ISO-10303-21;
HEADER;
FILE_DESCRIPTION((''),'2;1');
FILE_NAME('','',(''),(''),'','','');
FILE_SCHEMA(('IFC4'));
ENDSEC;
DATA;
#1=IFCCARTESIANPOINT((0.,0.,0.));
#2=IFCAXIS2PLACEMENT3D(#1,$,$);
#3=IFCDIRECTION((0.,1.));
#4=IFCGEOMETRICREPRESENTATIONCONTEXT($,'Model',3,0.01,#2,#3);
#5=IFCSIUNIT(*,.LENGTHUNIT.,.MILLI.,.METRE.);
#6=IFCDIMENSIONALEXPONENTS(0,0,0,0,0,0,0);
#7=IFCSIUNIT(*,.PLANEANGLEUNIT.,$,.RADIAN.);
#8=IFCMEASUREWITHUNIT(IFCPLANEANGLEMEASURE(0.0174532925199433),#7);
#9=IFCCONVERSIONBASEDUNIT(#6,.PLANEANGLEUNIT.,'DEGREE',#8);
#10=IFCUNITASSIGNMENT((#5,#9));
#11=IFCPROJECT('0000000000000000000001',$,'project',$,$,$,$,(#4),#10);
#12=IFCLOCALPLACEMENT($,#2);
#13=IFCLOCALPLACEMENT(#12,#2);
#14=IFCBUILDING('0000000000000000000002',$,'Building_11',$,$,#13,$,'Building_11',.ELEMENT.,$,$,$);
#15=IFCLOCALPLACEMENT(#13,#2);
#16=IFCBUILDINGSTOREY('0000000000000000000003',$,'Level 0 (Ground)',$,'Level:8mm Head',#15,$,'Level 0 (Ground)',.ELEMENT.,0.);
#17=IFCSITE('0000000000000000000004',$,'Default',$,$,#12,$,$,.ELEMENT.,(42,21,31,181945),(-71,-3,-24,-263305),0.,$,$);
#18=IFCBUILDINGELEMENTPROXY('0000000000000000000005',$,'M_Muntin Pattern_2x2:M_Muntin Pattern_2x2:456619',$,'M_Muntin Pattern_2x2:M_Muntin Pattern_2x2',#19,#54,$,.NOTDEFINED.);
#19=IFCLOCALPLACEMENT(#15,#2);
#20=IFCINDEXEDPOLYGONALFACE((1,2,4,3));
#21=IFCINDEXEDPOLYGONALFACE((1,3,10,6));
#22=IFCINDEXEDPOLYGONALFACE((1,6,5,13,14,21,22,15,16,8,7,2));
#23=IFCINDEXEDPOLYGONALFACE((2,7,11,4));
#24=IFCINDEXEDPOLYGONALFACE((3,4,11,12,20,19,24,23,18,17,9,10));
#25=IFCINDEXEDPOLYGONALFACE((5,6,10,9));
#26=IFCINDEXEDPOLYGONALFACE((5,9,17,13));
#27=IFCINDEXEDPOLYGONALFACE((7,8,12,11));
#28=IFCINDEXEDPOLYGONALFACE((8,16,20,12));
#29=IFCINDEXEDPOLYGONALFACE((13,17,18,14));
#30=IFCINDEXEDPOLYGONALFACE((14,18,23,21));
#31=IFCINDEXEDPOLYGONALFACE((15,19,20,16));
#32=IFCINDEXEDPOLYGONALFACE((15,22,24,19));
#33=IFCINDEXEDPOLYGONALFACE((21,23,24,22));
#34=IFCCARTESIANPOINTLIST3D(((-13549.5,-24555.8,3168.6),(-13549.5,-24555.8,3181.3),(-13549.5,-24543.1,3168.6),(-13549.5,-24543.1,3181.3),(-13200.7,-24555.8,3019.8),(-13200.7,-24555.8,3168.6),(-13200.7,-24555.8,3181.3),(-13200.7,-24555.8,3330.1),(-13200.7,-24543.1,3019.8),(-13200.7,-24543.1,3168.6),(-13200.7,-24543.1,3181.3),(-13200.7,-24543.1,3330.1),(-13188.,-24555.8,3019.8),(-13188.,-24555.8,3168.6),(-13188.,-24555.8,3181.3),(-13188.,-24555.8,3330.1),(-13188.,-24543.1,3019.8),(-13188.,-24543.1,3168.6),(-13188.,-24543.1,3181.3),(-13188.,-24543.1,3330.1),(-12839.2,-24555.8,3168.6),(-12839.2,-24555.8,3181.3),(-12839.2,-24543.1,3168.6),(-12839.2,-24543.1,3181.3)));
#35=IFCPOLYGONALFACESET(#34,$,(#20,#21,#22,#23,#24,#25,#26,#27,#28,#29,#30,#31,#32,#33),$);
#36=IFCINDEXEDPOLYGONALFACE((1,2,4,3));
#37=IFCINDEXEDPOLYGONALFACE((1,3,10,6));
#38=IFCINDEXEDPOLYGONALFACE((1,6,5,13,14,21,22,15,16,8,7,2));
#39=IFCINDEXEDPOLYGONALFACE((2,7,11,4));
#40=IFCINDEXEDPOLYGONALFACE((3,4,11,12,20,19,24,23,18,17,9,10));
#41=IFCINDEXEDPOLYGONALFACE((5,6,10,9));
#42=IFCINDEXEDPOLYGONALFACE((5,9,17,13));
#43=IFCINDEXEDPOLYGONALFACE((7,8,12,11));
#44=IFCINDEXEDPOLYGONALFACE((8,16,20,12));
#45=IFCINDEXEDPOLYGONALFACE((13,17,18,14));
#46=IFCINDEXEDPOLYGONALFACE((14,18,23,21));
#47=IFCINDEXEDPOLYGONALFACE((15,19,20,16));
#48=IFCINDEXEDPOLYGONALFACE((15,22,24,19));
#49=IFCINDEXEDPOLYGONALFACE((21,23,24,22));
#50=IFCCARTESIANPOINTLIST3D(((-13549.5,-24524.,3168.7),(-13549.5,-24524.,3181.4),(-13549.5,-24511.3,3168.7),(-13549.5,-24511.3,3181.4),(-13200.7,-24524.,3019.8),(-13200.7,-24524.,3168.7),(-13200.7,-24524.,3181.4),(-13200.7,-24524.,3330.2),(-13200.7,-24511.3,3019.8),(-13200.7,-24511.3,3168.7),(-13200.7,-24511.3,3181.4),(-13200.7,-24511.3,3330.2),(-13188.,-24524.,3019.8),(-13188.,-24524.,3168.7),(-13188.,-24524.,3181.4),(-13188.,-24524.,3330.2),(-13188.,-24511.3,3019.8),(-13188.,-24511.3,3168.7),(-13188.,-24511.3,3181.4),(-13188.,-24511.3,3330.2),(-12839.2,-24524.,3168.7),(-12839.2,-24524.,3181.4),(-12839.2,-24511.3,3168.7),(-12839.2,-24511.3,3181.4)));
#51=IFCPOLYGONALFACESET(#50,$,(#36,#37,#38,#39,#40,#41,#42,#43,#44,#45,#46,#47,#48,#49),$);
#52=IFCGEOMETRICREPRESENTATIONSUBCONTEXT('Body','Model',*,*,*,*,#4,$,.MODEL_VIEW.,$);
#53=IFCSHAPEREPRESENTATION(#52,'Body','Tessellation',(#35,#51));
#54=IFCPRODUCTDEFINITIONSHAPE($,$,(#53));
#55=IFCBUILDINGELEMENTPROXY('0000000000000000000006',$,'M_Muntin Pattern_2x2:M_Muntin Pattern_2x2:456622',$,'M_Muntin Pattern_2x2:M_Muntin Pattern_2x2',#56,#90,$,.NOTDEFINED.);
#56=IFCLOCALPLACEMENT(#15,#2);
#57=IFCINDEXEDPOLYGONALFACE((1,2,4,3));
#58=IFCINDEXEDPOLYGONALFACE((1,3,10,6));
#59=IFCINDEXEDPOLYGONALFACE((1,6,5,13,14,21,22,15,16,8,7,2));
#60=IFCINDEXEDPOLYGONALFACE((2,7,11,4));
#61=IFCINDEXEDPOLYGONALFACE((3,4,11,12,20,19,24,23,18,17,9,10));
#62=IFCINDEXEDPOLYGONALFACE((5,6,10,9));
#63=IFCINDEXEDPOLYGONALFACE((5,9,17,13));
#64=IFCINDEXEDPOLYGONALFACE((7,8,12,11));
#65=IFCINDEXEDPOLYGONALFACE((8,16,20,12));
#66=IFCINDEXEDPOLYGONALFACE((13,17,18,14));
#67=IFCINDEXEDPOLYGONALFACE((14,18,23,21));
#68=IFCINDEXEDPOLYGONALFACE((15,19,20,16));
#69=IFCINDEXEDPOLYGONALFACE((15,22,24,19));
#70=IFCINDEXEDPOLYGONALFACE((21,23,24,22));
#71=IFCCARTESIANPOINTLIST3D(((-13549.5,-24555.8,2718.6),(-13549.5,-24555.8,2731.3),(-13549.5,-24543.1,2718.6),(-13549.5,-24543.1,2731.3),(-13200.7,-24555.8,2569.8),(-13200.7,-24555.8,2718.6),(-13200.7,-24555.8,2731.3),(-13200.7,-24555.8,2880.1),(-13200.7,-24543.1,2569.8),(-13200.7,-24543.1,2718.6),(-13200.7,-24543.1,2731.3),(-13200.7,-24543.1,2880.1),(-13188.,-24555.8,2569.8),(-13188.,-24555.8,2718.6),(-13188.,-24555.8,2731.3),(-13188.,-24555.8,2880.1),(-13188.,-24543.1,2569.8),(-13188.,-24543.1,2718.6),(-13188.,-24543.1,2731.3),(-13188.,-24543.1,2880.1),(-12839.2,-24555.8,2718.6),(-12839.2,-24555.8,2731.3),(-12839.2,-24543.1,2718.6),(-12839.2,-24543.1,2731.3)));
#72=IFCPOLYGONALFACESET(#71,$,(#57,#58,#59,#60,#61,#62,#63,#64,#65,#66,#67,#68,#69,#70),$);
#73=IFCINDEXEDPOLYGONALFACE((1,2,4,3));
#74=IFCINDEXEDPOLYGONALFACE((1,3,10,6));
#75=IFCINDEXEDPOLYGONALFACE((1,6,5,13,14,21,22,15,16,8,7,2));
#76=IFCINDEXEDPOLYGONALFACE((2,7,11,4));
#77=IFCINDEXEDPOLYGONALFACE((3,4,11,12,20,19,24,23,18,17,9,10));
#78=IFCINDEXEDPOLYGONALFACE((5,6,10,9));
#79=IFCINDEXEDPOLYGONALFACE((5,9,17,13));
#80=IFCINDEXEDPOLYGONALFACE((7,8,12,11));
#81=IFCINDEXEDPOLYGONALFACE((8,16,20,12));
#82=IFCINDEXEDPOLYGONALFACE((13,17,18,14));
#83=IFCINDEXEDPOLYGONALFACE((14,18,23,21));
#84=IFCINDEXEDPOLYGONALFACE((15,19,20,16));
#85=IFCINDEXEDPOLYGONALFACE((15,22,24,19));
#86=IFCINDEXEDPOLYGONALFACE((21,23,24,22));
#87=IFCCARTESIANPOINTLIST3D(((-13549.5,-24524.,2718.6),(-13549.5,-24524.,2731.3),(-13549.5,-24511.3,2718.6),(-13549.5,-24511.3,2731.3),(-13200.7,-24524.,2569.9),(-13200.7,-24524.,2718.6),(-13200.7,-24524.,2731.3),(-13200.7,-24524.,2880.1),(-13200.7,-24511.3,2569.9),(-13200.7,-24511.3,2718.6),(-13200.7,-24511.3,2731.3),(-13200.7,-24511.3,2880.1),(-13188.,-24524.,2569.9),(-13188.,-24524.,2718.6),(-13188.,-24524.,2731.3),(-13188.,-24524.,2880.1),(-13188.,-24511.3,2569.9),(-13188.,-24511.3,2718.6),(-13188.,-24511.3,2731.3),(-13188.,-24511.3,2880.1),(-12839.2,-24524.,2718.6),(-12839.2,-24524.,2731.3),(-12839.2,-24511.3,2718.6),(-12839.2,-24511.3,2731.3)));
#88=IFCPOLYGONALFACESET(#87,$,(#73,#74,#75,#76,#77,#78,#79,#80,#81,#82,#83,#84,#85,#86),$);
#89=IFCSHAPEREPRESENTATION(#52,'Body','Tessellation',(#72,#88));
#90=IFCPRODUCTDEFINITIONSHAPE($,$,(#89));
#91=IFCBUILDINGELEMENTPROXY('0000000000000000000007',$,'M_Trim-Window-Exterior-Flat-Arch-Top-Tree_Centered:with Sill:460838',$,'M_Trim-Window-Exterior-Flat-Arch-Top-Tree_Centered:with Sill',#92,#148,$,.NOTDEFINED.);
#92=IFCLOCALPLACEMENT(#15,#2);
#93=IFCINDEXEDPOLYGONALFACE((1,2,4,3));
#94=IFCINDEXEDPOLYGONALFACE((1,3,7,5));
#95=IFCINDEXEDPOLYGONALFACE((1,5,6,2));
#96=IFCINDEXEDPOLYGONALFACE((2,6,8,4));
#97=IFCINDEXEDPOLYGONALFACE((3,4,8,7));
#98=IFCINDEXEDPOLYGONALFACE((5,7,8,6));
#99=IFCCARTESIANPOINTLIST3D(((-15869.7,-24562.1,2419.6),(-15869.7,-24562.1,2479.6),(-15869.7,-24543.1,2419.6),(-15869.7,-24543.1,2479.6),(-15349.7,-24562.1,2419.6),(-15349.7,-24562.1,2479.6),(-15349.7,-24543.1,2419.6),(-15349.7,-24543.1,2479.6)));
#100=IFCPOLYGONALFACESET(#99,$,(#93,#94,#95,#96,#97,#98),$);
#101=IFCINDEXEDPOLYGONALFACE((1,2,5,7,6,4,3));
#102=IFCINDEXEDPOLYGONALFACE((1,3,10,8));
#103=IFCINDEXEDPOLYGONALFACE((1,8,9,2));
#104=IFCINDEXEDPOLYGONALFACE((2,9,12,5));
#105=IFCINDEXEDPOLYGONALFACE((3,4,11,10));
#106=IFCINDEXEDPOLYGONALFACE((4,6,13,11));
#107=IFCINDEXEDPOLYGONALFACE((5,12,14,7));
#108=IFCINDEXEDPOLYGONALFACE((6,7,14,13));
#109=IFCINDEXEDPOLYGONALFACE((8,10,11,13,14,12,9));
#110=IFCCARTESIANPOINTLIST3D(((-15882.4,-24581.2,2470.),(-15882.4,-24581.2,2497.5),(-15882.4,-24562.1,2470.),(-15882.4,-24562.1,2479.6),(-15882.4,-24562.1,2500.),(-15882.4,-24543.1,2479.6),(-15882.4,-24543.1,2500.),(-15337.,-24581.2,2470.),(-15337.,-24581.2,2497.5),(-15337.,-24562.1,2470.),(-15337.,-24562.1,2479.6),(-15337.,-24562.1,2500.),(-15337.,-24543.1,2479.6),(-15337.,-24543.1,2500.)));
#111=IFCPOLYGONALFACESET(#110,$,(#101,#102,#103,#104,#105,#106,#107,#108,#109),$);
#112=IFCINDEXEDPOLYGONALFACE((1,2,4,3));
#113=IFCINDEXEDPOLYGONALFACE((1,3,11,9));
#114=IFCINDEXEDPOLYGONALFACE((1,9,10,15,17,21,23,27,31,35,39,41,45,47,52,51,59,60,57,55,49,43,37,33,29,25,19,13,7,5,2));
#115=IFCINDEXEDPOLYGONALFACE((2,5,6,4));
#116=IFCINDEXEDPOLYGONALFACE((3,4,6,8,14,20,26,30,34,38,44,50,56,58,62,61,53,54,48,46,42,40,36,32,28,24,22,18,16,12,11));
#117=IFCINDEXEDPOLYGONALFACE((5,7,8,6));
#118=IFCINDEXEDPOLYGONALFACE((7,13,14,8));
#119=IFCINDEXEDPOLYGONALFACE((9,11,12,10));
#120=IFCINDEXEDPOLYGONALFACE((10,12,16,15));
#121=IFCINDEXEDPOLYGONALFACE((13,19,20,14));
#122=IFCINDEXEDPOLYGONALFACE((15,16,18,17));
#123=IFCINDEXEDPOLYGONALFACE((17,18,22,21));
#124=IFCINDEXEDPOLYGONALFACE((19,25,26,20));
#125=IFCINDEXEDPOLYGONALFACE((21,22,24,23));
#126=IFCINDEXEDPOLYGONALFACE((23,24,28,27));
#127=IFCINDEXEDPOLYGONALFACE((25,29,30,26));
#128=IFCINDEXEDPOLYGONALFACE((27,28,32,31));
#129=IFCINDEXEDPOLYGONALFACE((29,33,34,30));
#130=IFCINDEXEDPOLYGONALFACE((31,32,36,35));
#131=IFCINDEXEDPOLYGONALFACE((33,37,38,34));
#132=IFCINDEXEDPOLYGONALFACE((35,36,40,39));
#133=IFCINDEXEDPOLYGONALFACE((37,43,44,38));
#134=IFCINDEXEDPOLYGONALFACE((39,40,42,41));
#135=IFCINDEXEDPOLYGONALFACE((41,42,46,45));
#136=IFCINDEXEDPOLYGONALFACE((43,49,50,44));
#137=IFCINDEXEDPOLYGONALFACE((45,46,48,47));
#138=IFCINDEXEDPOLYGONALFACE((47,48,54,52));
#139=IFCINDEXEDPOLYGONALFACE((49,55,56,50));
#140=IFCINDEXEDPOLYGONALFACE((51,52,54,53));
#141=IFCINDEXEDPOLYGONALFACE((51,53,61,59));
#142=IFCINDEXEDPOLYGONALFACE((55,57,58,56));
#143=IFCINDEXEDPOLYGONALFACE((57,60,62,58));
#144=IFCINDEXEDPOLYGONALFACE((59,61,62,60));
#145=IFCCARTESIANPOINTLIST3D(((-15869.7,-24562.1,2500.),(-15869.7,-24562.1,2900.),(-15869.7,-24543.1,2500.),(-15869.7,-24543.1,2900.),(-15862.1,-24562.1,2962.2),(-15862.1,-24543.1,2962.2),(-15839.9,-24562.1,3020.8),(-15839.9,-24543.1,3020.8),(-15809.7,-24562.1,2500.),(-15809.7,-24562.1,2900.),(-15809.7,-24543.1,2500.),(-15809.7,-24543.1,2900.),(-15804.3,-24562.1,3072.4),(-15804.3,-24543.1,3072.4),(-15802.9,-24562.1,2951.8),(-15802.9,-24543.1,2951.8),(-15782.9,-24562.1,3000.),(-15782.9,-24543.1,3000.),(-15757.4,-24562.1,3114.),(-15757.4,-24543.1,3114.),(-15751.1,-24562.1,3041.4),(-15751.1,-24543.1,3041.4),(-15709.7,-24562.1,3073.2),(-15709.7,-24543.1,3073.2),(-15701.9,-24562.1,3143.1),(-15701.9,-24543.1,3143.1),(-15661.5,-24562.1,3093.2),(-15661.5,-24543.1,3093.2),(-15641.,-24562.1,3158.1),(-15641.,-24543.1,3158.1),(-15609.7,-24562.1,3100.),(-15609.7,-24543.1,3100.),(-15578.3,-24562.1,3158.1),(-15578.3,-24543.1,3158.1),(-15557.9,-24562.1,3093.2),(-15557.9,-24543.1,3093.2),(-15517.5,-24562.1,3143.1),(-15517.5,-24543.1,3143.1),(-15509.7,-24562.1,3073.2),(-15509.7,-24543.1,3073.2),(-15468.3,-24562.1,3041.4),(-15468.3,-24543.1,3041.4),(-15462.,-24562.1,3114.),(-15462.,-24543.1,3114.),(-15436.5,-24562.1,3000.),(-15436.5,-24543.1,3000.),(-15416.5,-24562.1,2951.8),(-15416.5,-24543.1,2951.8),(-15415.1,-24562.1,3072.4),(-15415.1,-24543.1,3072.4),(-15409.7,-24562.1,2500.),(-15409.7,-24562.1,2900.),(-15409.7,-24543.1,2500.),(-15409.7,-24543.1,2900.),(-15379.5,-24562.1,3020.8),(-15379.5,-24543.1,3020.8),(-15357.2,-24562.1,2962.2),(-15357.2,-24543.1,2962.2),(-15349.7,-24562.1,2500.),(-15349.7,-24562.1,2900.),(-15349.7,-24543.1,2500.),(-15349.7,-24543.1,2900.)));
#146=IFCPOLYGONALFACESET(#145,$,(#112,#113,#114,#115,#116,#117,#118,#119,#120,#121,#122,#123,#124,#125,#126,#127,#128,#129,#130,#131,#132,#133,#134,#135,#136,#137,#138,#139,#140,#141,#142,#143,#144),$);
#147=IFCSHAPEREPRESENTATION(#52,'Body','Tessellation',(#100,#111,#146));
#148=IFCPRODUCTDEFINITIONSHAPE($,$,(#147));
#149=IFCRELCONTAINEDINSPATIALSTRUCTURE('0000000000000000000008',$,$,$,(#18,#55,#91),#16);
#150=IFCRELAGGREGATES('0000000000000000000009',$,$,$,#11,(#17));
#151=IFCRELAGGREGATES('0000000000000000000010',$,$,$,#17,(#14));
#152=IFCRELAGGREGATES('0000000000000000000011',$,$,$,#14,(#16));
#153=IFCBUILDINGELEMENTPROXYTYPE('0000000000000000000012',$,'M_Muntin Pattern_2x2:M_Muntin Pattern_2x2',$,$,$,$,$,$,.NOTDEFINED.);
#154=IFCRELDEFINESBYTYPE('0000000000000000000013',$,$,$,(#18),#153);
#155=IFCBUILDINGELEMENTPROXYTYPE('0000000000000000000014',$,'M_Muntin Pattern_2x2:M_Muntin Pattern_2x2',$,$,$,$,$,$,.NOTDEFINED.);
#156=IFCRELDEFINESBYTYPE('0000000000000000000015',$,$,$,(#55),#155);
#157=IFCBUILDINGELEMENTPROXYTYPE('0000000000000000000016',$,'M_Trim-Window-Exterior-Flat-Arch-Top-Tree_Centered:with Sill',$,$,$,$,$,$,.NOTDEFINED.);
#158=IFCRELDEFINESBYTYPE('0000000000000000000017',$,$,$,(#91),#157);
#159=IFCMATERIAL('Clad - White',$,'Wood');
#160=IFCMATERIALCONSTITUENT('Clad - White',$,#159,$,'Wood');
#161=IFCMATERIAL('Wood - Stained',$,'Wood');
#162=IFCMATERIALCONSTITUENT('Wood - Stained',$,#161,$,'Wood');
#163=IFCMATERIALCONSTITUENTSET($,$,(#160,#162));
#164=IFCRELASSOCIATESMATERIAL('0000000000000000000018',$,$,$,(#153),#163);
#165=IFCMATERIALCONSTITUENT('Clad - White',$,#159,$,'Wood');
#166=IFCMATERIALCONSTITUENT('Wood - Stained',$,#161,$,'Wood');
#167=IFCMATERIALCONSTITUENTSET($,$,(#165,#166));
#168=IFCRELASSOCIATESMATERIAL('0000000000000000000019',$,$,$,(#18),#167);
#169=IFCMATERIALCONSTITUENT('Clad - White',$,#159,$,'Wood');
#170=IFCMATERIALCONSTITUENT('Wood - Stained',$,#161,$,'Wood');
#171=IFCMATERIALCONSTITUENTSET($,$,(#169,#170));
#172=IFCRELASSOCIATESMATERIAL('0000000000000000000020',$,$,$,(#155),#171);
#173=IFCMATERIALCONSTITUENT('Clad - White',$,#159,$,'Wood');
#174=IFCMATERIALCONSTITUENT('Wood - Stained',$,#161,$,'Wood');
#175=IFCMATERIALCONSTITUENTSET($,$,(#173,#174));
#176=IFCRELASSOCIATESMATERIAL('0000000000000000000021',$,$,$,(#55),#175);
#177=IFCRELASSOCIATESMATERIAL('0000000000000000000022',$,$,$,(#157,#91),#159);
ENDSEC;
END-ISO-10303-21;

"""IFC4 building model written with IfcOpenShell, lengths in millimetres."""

from ifc_helpers import new_model, entity, si_unit, converted_unit, direction, frame, origin, place, context, subcontext, project, spatial, line, arc, indexed_curve, outline, extrude, source, transform, mapped, material, constituent, constituent_set, type_object, type_shapes, element, save


model = new_model("IFC4")

# Units and contexts
model_context = context("Model", 3, precision=0.01, world=origin(), true_north=direction((0.0, 1.0)))
body_context = subcontext(model_context, "Body", "Model", "MODEL_VIEW")
ifc_project = project(units=[si_unit("LENGTHUNIT", "METRE", prefix="MILLI"), converted_unit("PLANEANGLEUNIT", "DEGREE", entity("IfcPlaneAngleMeasure", 0.0174532925199433), si_unit("PLANEANGLEUNIT", "RADIAN"), dimensions=[0, 0, 0, 0, 0, 0, 0])], contexts=[model_context])

# Site, building, storey
site_placement = place(None, origin())
site = spatial("IfcSite", under=ifc_project, at=site_placement, Name="Default", CompositionType="ELEMENT", RefLatitude=(42, 21, 31, 181945), RefLongitude=(-71, -3, -24, -263305), RefElevation=0.0)
building_placement = place(site_placement, origin())
building = spatial("IfcBuilding", under=site, at=building_placement, Name="Building_11", LongName="Building_11", CompositionType="ELEMENT")
storey_placement = place(building_placement, origin())
storey = spatial("IfcBuildingStorey", under=building, at=storey_placement, Name="Level 0 (Ground)", ObjectType="Level:8mm Head", LongName="Level 0 (Ground)", CompositionType="ELEMENT", Elevation=0.0)

# Building element proxies
ifc_material_1 = material(Name="Clad - White", Category="Wood")
ifc_material_2 = material(Name="Wood - Stained", Category="Wood")
ifc_constituent_1 = constituent(ifc_material_1, Name="Clad - White", Category="Wood")
ifc_constituent_2 = constituent(ifc_material_2, Name="Wood - Stained", Category="Wood")
ifc_constituent_set_1 = constituent_set(constituents=[ifc_constituent_1, ifc_constituent_2])
ifc_constituent_3 = constituent(ifc_material_1, Name="Clad - White", Category="Wood")
ifc_constituent_4 = constituent(ifc_material_2, Name="Wood - Stained", Category="Wood")
ifc_constituent_set_2 = constituent_set(constituents=[ifc_constituent_3, ifc_constituent_4])
building_element_proxy_type_1 = type_object("IfcBuildingElementProxyType", Name="M_Muntin Pattern_2x2:M_Muntin Pattern_2x2", PredefinedType="NOTDEFINED", material=ifc_constituent_set_2)
shared_shape_1 = source(origin(), body_context, "Body", "SweptSolid", [
    extrude(outline(indexed_curve([(6.4, -6.4), (155.1, -6.4), (155.1, 6.3), (6.4, 6.3), (6.4, 355.2), (-6.3, 355.2), (-6.3, 6.3), (-155.2, 6.3), (-155.2, -6.4), (-6.3, -6.4), (-6.3, -355.1), (6.4, -355.1), (6.4, -6.4)], self_intersect=False)), frame((0.0, 9.5, 155.1), z_axis=(0.0, 1.0, 0.0), x_axis=(0.0, 0.0, 1.0)), (0.0, 0.0, 1.0), 12.7),
    extrude(outline(indexed_curve([(6.4, -6.4), (155.2, -6.4), (155.2, 6.3), (6.4, 6.3), (6.4, 355.2), (-6.3, 355.2), (-6.3, 6.3), (-155.2, 6.3), (-155.2, -6.4), (-6.3, -6.4), (-6.3, -355.1), (6.4, -355.1), (6.4, -6.4)], self_intersect=False)), frame((0.0, -22.2, 155.2), z_axis=(0.0, 1.0, 0.0), x_axis=(0.0, 0.0, 1.0)), (0.0, 0.0, 1.0), 12.7),
])
type_shapes(building_element_proxy_type_1, [shared_shape_1])
proxy_1_placement = place(storey_placement, frame((-13194.3, -24533.6, 3019.8), z_axis=(0.0, 0.0, 1.0), x_axis=(-1.0, 0.0, 0.0)))
element("IfcBuildingElementProxy", 1, at=proxy_1_placement, inside=storey, type_object=building_element_proxy_type_1, material=ifc_constituent_set_1, Name="M_Muntin Pattern_2x2:M_Muntin Pattern_2x2:456619", ObjectType="M_Muntin Pattern_2x2:M_Muntin Pattern_2x2", PredefinedType="NOTDEFINED", context=body_context, shape_type="MappedRepresentation", body=[
    mapped(shared_shape_1, transform((0.0, 0.0, 0.0), scale=1.0)),
])
ifc_constituent_5 = constituent(ifc_material_1, Name="Clad - White", Category="Wood")
ifc_constituent_6 = constituent(ifc_material_2, Name="Wood - Stained", Category="Wood")
ifc_constituent_set_3 = constituent_set(constituents=[ifc_constituent_5, ifc_constituent_6])
ifc_constituent_7 = constituent(ifc_material_1, Name="Clad - White", Category="Wood")
ifc_constituent_8 = constituent(ifc_material_2, Name="Wood - Stained", Category="Wood")
ifc_constituent_set_4 = constituent_set(constituents=[ifc_constituent_7, ifc_constituent_8])
building_element_proxy_type_2 = type_object("IfcBuildingElementProxyType", Name="M_Muntin Pattern_2x2:M_Muntin Pattern_2x2", PredefinedType="NOTDEFINED", material=ifc_constituent_set_4)
shared_shape_2 = source(origin(), body_context, "Body", "SweptSolid", [
    extrude(outline(indexed_curve([(6.4, -6.4), (155.1, -6.4), (155.1, 6.3), (6.4, 6.3), (6.4, 355.2), (-6.3, 355.2), (-6.3, 6.3), (-155.1, 6.3), (-155.1, -6.4), (-6.3, -6.4), (-6.3, -355.1), (6.4, -355.1), (6.4, -6.4)], self_intersect=False)), frame((0.0, 9.5, 155.1), z_axis=(0.0, 1.0, 0.0), x_axis=(0.0, 0.0, 1.0)), (0.0, 0.0, 1.0), 12.7),
    extrude(outline(indexed_curve([(6.4, -6.4), (155.1, -6.4), (155.1, 6.3), (6.4, 6.3), (6.4, 355.2), (-6.3, 355.2), (-6.3, 6.3), (-155.1, 6.3), (-155.1, -6.4), (-6.3, -6.4), (-6.3, -355.1), (6.4, -355.1), (6.4, -6.4)], self_intersect=False)), frame((0.0, -22.2, 155.1), z_axis=(0.0, 1.0, 0.0), x_axis=(0.0, 0.0, 1.0)), (0.0, 0.0, 1.0), 12.7),
])
type_shapes(building_element_proxy_type_2, [shared_shape_2])
proxy_2_placement = place(storey_placement, frame((-13194.3, -24533.6, 2569.9), z_axis=(0.0, 0.0, 1.0), x_axis=(-1.0, 0.0, 0.0)))
element("IfcBuildingElementProxy", 2, at=proxy_2_placement, inside=storey, type_object=building_element_proxy_type_2, material=ifc_constituent_set_3, Name="M_Muntin Pattern_2x2:M_Muntin Pattern_2x2:456622", ObjectType="M_Muntin Pattern_2x2:M_Muntin Pattern_2x2", PredefinedType="NOTDEFINED", context=body_context, shape_type="MappedRepresentation", body=[
    mapped(shared_shape_2, transform((0.0, 0.0, 0.0), scale=1.0)),
])
building_element_proxy_type_3 = type_object("IfcBuildingElementProxyType", Name="M_Trim-Window-Exterior-Flat-Arch-Top-Tree_Centered:with Sill", PredefinedType="NOTDEFINED", material=ifc_material_1)
shared_shape_3 = source(origin(), body_context, "Body", "SweptSolid", [
    extrude(outline(indexed_curve([(-260.0, -30.0), (260.0, -30.0), (260.0, 30.0), (-260.0, 30.0), (-260.0, -30.0)], self_intersect=False)), frame((0.0, -650.4, 0.0), z_axis=(0.0, 0.0, 1.0), x_axis=(-1.0, 0.0, 0.0)), (0.0, 0.0, 1.0), 19.1),
    extrude(outline(indexed_curve([(-19.0, -15.2), (0.0, -15.2), (0.0, -5.7), (19.0, -5.7), (19.0, 14.8), (0.0, 14.8), (-19.0, 12.3), (-19.0, -15.2)], self_intersect=False)), frame((-272.7, -614.8, 19.0), z_axis=(1.0, 0.0, 0.0), x_axis=(0.0, 0.0, -1.0)), (0.0, 0.0, 1.0), 545.4),
    extrude(outline(indexed_curve([(-200.0, -260.0), (200.0, -260.0), (200.0, -200.0), (-200.0, -200.0), (-400.0, 0.0), (-200.0, 200.0), (200.0, 200.0), (200.0, 260.0), (-200.0, 260.0), (-460.0, 0.0)], segments=[line(1, 2, 3, 4), arc(4, 5, 6), line(6, 7, 8, 9), arc(9, 10, 1)], self_intersect=False)), frame((0.0, -400.0, 0.0), z_axis=(0.0, 0.0, 1.0), x_axis=(0.0, -1.0, 0.0)), (0.0, 0.0, 1.0), 19.1),
])
type_shapes(building_element_proxy_type_3, [shared_shape_3])
proxy_3_placement = place(storey_placement, frame((-15609.7, -24543.1, 3100.0), z_axis=(0.0, -1.0, 0.0), x_axis=(1.0, 0.0, 0.0)))
element("IfcBuildingElementProxy", 3, at=proxy_3_placement, inside=storey, type_object=building_element_proxy_type_3, material=ifc_material_1, Name="M_Trim-Window-Exterior-Flat-Arch-Top-Tree_Centered:with Sill:460838", ObjectType="M_Trim-Window-Exterior-Flat-Arch-Top-Tree_Centered:with Sill", PredefinedType="NOTDEFINED", context=body_context, shape_type="MappedRepresentation", body=[
    mapped(shared_shape_3, transform((0.0, 0.0, 0.0), scale=1.0)),
])

save(model, "model.ifc")
